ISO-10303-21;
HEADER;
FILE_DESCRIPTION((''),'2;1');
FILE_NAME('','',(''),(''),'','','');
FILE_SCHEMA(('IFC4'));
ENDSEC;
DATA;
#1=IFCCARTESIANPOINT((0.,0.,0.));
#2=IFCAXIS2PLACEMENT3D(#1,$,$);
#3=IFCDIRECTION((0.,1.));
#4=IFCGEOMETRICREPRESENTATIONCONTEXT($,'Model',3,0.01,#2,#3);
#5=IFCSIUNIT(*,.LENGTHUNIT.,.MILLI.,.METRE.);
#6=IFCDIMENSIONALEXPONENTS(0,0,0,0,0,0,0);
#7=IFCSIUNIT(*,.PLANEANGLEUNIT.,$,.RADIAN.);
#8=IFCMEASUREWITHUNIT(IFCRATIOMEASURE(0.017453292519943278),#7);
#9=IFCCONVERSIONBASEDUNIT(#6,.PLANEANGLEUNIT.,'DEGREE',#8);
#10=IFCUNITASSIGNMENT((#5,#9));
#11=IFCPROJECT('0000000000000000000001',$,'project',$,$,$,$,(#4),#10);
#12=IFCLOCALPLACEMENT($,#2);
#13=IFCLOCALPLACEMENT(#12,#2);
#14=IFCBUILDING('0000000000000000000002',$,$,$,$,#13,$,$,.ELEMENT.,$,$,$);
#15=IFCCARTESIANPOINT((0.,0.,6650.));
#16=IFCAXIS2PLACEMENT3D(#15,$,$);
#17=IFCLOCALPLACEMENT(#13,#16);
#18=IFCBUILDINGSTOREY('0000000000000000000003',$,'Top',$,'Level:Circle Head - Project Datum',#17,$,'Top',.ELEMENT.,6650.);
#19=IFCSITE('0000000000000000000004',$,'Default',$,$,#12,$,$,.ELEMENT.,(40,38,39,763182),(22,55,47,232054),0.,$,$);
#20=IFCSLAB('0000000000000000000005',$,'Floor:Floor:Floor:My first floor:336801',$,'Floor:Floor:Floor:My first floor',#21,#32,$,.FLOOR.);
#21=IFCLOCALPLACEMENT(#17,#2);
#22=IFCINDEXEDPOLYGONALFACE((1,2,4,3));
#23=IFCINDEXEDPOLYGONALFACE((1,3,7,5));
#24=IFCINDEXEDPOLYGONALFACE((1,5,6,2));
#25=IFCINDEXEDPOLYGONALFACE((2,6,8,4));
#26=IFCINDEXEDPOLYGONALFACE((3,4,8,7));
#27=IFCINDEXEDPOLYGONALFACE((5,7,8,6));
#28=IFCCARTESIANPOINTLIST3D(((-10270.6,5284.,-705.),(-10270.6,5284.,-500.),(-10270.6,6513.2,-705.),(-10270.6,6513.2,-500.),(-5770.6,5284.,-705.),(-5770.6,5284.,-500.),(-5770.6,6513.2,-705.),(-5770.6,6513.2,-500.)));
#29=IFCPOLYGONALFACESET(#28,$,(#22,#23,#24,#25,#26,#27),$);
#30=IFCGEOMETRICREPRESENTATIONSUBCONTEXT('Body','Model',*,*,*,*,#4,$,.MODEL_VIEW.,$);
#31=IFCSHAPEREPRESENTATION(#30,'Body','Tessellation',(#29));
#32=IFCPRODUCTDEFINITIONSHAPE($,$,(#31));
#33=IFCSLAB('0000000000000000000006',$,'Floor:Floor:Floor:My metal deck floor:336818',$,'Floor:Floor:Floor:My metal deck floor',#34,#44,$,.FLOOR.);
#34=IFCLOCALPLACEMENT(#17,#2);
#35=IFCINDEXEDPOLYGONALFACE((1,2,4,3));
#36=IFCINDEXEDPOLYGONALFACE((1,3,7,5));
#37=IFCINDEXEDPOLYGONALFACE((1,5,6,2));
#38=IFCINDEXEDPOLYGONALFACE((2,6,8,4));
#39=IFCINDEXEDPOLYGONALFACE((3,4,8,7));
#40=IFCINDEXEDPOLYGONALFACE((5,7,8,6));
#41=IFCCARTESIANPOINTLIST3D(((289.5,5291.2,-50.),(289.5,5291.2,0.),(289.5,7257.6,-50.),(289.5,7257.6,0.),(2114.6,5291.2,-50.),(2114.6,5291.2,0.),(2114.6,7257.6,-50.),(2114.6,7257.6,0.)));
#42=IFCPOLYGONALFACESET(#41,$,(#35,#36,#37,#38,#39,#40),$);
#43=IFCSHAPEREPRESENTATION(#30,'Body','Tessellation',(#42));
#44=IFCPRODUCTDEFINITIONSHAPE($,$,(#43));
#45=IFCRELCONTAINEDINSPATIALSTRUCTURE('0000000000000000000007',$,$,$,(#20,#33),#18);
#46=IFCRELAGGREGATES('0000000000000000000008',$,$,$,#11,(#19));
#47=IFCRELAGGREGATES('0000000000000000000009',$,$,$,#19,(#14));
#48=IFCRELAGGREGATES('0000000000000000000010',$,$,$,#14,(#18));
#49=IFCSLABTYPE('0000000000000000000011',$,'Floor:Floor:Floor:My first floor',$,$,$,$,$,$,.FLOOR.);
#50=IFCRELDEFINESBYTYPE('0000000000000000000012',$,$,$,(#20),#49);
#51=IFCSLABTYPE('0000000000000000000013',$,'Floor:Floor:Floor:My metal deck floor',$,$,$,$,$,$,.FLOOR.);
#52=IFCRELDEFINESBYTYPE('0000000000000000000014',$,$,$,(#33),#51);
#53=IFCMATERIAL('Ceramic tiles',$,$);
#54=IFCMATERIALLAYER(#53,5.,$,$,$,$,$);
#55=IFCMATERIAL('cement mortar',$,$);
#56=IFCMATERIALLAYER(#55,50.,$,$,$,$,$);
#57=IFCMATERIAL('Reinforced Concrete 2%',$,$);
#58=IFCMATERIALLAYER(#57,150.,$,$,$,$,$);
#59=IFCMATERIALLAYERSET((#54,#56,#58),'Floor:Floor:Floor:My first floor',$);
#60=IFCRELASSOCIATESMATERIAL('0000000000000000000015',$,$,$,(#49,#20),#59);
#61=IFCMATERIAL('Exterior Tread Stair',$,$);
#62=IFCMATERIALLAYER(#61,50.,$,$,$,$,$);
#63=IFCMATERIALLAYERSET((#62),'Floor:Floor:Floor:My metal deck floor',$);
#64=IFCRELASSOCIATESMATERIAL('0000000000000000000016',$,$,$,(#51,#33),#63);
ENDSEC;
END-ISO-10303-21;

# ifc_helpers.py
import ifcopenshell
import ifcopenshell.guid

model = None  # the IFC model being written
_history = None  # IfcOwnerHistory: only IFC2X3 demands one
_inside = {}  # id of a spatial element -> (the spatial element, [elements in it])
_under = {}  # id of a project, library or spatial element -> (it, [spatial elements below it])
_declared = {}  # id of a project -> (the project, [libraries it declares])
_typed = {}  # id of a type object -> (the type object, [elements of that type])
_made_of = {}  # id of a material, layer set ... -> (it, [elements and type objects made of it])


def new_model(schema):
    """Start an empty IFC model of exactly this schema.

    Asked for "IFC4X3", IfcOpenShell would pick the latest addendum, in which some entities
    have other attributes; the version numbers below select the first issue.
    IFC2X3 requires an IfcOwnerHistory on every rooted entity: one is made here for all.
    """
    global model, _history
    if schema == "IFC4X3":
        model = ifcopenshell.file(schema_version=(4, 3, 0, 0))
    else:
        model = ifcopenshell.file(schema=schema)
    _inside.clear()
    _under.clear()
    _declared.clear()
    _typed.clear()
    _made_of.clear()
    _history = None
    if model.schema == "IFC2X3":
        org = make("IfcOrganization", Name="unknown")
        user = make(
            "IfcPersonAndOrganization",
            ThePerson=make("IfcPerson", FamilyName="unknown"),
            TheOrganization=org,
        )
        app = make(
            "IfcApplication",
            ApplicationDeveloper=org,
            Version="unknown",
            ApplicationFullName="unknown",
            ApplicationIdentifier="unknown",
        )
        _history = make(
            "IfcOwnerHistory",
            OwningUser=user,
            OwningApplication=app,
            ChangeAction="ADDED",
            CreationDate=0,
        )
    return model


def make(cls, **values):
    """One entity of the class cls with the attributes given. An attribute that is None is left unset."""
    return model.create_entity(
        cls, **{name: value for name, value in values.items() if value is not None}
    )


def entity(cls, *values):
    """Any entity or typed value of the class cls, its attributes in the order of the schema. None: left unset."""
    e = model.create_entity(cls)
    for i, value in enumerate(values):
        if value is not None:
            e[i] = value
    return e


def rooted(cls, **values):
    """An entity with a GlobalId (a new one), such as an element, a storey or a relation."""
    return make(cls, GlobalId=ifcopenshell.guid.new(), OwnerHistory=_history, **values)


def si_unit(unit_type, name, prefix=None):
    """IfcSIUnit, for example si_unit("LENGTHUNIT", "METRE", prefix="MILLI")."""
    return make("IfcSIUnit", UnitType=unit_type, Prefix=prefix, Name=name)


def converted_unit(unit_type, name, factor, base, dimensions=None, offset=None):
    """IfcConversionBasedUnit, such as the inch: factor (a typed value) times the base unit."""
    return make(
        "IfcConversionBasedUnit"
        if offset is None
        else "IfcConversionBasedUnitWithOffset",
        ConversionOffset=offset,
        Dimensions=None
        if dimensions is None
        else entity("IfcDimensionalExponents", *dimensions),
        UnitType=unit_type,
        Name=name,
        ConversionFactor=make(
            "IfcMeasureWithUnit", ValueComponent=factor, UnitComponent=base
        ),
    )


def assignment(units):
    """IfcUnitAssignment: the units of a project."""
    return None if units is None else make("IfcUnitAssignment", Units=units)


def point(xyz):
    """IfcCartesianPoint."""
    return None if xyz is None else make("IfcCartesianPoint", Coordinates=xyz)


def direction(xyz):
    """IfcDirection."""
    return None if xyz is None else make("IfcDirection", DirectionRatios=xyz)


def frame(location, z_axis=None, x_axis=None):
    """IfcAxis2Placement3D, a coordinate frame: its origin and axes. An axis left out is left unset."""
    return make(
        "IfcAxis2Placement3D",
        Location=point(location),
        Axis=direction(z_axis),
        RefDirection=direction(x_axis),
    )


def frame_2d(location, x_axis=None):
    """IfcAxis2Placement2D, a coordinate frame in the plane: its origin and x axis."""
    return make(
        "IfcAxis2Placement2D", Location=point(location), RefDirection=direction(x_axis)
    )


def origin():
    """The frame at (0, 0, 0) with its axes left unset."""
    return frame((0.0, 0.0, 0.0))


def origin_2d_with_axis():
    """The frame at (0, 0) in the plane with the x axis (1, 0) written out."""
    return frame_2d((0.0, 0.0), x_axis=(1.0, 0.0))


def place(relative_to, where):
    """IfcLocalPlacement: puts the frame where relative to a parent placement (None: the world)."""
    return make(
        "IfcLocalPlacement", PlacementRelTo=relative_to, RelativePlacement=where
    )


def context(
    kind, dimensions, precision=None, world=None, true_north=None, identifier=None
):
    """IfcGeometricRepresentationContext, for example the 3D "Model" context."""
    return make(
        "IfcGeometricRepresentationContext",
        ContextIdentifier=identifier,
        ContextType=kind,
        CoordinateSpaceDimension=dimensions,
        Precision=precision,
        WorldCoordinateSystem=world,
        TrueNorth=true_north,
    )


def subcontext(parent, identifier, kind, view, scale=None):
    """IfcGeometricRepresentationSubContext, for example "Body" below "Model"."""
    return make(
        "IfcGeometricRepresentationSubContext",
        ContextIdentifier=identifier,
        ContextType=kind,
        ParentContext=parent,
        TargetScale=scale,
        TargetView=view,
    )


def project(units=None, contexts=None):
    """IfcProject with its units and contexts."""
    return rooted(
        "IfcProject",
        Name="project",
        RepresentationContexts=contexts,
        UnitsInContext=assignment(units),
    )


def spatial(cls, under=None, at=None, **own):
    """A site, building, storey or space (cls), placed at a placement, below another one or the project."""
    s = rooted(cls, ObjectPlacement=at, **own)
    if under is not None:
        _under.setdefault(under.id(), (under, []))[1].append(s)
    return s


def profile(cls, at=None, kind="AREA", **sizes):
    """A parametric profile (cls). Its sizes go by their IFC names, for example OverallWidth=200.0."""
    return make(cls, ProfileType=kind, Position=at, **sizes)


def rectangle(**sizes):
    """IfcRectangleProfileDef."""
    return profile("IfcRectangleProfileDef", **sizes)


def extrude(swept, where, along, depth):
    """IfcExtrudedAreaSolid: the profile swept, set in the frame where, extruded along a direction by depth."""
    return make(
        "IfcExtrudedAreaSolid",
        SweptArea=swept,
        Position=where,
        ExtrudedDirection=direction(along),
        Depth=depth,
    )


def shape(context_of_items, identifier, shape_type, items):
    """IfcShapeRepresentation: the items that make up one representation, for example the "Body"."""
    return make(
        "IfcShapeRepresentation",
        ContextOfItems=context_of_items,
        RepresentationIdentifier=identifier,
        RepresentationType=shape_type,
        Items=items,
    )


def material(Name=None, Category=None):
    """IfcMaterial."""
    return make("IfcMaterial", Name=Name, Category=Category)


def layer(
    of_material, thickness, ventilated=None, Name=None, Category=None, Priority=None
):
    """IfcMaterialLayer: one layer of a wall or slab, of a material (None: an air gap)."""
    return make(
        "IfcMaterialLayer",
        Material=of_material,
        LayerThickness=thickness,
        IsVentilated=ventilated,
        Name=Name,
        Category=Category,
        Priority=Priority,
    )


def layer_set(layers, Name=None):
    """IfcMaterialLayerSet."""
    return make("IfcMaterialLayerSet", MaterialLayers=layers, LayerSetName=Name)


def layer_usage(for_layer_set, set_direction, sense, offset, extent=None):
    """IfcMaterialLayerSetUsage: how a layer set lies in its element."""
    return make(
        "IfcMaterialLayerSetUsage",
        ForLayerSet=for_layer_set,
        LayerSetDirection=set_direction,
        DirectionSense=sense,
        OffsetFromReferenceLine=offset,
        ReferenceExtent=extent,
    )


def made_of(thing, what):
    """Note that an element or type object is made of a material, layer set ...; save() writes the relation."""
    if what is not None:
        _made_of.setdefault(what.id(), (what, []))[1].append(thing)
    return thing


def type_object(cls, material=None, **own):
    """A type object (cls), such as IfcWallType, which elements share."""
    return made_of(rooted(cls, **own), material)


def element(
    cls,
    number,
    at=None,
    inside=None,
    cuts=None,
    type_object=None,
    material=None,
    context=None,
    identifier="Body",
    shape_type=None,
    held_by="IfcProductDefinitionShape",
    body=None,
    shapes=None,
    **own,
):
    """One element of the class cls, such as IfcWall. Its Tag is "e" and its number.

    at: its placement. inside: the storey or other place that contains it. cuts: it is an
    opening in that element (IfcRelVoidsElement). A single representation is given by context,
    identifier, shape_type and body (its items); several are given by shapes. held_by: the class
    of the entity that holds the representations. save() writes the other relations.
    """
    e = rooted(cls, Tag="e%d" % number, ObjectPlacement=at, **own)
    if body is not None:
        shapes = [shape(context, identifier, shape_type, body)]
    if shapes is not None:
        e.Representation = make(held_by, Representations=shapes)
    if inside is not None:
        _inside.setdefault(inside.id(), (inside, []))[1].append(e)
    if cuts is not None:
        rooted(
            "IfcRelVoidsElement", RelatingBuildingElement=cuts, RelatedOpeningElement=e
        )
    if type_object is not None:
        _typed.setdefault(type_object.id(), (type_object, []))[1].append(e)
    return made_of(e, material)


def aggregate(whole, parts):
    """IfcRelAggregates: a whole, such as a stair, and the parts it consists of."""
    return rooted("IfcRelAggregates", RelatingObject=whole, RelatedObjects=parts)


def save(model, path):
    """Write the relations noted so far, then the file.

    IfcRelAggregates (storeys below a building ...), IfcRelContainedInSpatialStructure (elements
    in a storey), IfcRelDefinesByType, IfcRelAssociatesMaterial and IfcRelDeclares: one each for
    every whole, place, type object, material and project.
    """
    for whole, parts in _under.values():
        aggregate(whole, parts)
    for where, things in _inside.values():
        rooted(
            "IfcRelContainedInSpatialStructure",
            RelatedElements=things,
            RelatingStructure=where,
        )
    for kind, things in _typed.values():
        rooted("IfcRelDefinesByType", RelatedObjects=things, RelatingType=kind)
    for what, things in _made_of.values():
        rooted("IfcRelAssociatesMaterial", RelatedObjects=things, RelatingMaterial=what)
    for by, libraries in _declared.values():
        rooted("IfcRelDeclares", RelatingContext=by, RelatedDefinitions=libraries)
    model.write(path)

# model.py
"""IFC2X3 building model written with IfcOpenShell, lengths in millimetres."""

from ifc_helpers import new_model, entity, si_unit, converted_unit, direction, frame, origin, origin_2d_with_axis, place, context, subcontext, project, spatial, rectangle, extrude, material, layer, layer_set, layer_usage, type_object, element, save


model = new_model("IFC2X3")

# Units and contexts
model_context = context("Model", 3, precision=0.01, world=origin(), true_north=direction((0.0, 1.0)))
body_context = subcontext(model_context, "Body", "Model", "MODEL_VIEW")
ifc_project = project(units=[si_unit("LENGTHUNIT", "METRE", prefix="MILLI"), converted_unit("PLANEANGLEUNIT", "DEGREE", entity("IfcRatioMeasure", 0.017453292519943278), si_unit("PLANEANGLEUNIT", "RADIAN"), dimensions=[0, 0, 0, 0, 0, 0, 0])], contexts=[model_context])

# Site, building, storey
site_placement = place(None, origin())
site = spatial("IfcSite", under=ifc_project, at=site_placement, Name="Default", CompositionType="ELEMENT", RefLatitude=(40, 38, 39, 763182), RefLongitude=(22, 55, 47, 232054), RefElevation=0.0)
building_placement = place(site_placement, origin())
building = spatial("IfcBuilding", under=site, at=building_placement, CompositionType="ELEMENT")
storey_placement = place(building_placement, frame((0.0, 0.0, 6650.0)))
storey = spatial("IfcBuildingStorey", under=building, at=storey_placement, Name="Top", ObjectType="Level:Circle Head - Project Datum", LongName="Top", CompositionType="ELEMENT", Elevation=6650.0)

# Slabs
ifc_material_1 = material(Name="Ceramic tiles")
ifc_layer_1 = layer(ifc_material_1, 5.0)
ifc_material_2 = material(Name="cement mortar")
ifc_layer_2 = layer(ifc_material_2, 50.0)
ifc_material_3 = material(Name="Reinforced Concrete 2%")
ifc_layer_3 = layer(ifc_material_3, 150.0)
ifc_layer_set_1 = layer_set([ifc_layer_1, ifc_layer_2, ifc_layer_3], Name="Floor:Floor:Floor:My first floor")
ifc_layer_usage_1 = layer_usage(ifc_layer_set_1, "AXIS3", "POSITIVE", 0.0)
slab_type_1 = type_object("IfcSlabType", Name="Floor:Floor:Floor:My first floor", PredefinedType="FLOOR", material=ifc_layer_set_1)
slab_1_placement = place(storey_placement, origin())
element("IfcSlab", 1, at=slab_1_placement, inside=storey, type_object=slab_type_1, material=ifc_layer_usage_1, Name="Floor:Floor:Floor:My first floor:336801", ObjectType="Floor:Floor:Floor:My first floor", PredefinedType="FLOOR", context=body_context, shape_type="SweptSolid", body=[
    extrude(rectangle(XDim=1229.1, YDim=4500.0, at=origin_2d_with_axis()), frame((-8020.6, 5898.6, -500.0), z_axis=(0.0, 0.0, -1.0), x_axis=(0.0, 1.0, 0.0)), (0.0, 0.0, 1.0), 205.0),
])
ifc_material_4 = material(Name="Exterior Tread Stair")
ifc_layer_4 = layer(ifc_material_4, 50.0)
ifc_layer_set_2 = layer_set([ifc_layer_4], Name="Floor:Floor:Floor:My metal deck floor")
ifc_layer_usage_2 = layer_usage(ifc_layer_set_2, "AXIS3", "POSITIVE", 0.0)
slab_type_2 = type_object("IfcSlabType", Name="Floor:Floor:Floor:My metal deck floor", PredefinedType="FLOOR", material=ifc_layer_set_2)
slab_2_placement = place(storey_placement, origin())
element("IfcSlab", 2, at=slab_2_placement, inside=storey, type_object=slab_type_2, material=ifc_layer_usage_2, Name="Floor:Floor:Floor:My metal deck floor:336818", ObjectType="Floor:Floor:Floor:My metal deck floor", PredefinedType="FLOOR", context=body_context, shape_type="SweptSolid", body=[
    extrude(rectangle(XDim=1966.4, YDim=1825.0, at=origin_2d_with_axis()), frame((1202.1, 6274.4, 0.0), z_axis=(0.0, 0.0, -1.0), x_axis=(0.0, 1.0, 0.0)), (0.0, 0.0, 1.0), 50.0),
])

save(model, "model.ifc")
